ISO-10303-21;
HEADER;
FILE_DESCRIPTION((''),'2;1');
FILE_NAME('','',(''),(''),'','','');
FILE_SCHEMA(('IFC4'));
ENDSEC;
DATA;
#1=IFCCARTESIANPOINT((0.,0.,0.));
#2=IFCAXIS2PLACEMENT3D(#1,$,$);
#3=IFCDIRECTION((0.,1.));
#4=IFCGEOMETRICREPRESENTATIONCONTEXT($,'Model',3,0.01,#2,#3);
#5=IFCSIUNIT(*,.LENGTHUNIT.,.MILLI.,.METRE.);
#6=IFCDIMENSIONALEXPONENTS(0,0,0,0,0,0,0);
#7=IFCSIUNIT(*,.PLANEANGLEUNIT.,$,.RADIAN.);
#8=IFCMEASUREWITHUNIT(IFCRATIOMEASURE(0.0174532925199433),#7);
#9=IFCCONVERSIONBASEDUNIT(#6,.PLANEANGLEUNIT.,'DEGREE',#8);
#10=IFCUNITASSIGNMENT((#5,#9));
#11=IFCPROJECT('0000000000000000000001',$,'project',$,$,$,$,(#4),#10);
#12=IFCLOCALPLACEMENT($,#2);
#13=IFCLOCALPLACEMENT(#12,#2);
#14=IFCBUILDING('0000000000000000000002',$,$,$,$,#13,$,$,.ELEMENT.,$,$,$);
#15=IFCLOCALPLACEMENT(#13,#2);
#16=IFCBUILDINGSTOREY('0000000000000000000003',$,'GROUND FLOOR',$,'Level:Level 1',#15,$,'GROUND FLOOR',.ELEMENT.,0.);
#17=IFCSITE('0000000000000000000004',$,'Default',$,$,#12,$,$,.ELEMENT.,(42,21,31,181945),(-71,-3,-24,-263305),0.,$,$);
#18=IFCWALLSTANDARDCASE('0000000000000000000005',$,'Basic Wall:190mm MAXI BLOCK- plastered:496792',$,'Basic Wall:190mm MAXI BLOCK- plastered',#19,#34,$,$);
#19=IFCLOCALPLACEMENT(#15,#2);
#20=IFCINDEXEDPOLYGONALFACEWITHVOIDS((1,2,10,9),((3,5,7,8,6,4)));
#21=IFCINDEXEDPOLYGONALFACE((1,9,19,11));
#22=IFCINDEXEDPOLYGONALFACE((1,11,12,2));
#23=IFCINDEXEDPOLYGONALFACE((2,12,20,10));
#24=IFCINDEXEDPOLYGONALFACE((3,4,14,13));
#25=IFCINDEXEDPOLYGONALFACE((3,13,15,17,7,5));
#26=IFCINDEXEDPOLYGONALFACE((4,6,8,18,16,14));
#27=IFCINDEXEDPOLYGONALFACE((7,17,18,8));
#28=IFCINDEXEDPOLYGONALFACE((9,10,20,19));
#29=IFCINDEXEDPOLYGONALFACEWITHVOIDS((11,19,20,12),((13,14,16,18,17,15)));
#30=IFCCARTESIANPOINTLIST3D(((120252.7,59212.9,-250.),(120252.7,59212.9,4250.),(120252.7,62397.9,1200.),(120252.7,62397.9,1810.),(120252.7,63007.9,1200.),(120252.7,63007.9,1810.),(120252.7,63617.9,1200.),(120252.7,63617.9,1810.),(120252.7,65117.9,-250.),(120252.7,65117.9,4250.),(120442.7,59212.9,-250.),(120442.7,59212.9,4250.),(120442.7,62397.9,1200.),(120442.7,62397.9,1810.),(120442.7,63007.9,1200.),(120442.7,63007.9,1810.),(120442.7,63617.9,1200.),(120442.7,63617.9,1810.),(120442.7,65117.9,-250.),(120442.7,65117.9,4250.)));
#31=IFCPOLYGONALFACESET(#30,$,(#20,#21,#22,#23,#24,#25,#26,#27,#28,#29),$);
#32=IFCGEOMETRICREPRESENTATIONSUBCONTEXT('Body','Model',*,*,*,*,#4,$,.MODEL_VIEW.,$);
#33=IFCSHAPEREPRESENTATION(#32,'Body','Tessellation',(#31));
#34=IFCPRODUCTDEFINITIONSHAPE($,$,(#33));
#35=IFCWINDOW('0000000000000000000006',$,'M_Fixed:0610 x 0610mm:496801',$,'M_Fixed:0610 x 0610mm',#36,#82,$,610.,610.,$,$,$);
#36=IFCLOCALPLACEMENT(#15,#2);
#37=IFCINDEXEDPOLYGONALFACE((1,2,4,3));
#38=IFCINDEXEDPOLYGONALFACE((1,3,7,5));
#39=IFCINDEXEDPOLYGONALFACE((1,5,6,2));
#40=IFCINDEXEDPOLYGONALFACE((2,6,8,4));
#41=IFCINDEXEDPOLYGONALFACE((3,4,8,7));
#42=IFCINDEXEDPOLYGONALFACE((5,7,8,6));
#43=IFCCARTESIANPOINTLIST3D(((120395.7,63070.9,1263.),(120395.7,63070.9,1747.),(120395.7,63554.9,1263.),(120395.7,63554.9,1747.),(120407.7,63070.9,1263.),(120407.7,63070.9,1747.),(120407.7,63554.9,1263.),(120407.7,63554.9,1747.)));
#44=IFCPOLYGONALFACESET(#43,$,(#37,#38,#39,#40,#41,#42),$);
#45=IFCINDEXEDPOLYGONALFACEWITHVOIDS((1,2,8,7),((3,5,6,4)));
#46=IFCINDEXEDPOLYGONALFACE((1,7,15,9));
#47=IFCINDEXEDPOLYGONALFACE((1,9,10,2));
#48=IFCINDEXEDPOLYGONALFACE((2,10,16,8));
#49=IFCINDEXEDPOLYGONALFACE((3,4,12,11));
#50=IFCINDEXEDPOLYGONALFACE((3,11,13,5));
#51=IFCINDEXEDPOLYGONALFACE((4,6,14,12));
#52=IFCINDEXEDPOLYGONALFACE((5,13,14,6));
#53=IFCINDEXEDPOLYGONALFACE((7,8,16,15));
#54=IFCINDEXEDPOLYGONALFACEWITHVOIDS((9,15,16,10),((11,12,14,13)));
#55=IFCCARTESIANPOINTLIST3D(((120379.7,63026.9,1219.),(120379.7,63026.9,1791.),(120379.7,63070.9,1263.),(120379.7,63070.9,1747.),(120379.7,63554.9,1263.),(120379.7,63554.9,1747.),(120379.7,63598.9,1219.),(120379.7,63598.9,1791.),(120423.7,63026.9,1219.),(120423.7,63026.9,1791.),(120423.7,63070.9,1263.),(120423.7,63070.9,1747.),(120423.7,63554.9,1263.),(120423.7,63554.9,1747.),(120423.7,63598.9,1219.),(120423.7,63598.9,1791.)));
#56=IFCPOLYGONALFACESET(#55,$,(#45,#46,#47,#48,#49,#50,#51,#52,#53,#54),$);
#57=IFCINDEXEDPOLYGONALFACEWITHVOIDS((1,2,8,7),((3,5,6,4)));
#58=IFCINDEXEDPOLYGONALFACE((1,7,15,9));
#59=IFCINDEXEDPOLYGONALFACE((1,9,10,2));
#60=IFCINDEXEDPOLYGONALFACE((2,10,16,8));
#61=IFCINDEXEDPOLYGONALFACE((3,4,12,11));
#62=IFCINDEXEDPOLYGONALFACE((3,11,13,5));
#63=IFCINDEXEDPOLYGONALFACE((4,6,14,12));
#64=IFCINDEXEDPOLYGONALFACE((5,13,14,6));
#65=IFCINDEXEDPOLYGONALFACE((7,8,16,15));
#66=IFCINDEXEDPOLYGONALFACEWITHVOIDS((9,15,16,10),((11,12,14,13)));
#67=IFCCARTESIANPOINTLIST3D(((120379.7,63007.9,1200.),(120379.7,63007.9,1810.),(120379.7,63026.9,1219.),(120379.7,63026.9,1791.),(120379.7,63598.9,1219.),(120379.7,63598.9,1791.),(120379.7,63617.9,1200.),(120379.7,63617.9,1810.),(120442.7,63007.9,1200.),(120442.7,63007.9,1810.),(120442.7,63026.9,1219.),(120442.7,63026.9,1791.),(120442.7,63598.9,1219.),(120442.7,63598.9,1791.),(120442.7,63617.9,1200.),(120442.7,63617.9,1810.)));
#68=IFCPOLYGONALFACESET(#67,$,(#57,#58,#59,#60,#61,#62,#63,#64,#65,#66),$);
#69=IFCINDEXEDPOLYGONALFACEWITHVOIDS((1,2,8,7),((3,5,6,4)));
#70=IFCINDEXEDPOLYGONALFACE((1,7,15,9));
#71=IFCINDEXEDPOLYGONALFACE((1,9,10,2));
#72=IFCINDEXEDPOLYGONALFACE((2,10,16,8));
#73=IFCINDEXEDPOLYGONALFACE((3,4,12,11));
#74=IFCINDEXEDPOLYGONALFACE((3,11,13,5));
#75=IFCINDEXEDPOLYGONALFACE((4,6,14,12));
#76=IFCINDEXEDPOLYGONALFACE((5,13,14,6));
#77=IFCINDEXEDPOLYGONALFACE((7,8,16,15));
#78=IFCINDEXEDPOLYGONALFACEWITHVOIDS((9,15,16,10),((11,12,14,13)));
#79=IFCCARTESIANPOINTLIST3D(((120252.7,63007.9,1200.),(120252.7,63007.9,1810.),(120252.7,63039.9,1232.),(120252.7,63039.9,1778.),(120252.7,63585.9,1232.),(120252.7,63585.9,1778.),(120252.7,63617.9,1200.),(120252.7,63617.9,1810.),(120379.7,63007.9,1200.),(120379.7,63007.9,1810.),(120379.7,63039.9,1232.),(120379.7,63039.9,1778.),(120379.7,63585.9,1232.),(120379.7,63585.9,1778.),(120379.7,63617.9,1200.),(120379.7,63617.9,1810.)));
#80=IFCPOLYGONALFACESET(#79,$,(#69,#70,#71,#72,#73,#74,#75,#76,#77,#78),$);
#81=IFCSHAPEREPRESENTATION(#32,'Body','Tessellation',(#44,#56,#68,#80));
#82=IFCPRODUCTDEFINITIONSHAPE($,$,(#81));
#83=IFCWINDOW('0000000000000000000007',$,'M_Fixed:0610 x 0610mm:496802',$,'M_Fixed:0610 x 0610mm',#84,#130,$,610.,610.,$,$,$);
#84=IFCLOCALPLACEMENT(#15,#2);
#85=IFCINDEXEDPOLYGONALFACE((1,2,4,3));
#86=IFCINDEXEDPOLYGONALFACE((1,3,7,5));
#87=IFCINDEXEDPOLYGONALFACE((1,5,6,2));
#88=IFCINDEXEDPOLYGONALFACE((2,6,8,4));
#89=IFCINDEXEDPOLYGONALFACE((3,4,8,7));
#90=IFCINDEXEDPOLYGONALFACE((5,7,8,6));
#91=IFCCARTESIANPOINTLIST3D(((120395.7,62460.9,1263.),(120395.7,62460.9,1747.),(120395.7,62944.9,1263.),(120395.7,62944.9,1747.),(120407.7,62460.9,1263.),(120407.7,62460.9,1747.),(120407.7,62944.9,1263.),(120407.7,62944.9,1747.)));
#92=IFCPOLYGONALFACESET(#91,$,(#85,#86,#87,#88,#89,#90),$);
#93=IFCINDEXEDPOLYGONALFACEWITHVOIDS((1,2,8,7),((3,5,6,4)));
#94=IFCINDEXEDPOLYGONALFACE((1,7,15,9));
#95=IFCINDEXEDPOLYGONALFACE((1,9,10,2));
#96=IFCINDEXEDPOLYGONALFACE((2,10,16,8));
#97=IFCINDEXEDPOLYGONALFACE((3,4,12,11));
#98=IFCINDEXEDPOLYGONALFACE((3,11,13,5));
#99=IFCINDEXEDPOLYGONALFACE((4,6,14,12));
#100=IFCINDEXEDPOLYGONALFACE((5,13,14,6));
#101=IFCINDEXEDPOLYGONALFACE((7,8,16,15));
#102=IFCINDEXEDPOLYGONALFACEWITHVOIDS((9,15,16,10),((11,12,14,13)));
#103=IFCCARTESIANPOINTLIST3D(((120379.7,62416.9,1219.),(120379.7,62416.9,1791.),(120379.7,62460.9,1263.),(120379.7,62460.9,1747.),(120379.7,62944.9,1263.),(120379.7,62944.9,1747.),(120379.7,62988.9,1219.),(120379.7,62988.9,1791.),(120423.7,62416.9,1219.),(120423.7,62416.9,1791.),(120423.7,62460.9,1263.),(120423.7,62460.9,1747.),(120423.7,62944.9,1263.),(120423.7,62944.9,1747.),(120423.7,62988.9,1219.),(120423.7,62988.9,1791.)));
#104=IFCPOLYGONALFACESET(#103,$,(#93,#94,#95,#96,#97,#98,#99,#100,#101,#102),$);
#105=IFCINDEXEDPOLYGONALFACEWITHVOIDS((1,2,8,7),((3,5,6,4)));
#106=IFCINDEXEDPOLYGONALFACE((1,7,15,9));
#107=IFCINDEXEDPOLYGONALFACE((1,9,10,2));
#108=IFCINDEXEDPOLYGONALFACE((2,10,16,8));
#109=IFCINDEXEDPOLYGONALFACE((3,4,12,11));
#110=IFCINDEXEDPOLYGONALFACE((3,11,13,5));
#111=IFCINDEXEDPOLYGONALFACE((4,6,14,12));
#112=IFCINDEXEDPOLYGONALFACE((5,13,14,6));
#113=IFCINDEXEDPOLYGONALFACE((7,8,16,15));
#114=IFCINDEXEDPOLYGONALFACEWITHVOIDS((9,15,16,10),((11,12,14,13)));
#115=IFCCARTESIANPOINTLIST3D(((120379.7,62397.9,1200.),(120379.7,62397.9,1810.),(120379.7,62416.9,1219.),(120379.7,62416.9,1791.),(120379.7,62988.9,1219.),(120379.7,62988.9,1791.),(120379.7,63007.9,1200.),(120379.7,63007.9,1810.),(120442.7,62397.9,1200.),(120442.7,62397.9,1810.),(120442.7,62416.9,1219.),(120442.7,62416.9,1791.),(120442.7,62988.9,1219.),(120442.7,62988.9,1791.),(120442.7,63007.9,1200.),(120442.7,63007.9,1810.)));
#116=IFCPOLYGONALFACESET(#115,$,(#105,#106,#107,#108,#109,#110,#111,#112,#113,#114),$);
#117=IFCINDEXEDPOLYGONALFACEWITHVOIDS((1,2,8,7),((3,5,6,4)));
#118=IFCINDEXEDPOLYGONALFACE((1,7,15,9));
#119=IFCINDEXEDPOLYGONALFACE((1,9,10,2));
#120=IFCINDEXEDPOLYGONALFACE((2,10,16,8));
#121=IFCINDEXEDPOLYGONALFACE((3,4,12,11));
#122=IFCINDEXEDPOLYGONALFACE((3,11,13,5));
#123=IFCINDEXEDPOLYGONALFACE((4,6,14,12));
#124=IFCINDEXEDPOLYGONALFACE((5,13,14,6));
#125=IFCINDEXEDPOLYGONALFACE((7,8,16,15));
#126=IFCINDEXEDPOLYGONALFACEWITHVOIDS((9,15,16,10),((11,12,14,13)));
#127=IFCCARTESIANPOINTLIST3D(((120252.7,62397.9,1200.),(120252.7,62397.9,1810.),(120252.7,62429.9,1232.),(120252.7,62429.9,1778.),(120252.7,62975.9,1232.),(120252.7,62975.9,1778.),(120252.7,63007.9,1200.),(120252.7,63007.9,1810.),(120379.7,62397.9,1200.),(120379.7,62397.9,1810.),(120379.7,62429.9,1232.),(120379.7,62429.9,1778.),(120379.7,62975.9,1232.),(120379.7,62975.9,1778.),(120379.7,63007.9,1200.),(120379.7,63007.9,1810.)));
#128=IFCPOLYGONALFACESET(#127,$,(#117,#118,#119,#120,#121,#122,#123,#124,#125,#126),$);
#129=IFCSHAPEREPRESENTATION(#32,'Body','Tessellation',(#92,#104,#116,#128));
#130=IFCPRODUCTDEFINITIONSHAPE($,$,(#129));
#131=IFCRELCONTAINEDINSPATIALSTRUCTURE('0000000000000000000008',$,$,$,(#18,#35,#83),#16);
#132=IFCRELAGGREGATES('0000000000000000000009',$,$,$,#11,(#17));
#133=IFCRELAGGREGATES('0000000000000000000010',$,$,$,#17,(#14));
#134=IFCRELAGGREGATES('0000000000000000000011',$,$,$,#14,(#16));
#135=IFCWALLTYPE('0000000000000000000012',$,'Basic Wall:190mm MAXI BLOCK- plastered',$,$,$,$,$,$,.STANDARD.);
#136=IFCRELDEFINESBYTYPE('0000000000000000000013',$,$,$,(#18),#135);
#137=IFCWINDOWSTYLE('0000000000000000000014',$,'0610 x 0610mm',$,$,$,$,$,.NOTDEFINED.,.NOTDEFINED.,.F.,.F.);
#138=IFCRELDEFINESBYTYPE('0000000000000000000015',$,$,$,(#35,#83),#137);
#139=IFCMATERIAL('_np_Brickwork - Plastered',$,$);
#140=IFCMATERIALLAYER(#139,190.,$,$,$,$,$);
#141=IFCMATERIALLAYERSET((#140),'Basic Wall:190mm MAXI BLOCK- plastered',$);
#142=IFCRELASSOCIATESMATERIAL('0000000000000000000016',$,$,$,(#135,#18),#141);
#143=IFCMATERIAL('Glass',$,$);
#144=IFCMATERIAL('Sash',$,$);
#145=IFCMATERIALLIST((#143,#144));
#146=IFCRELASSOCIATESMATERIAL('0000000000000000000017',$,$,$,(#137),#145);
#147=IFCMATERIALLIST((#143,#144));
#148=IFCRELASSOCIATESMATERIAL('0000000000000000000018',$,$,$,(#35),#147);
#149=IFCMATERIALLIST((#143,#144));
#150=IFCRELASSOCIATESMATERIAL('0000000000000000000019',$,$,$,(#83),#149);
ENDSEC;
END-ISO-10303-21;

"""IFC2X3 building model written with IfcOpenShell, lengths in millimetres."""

from ifc_helpers import new_model, entity, si_unit, converted_unit, direction, frame, frame_2d, origin, place, context, subcontext, project, spatial, polyline, rectangle, outline, extrude, source, transform, mapped, material, material_list, layer, layer_set, layer_usage, type_object, type_shapes, element, fill, save


model = new_model("IFC2X3")

# Units and contexts
model_context = context("Model", 3, precision=0.01, world=origin(), true_north=direction((0.0, 1.0)))
body_context = subcontext(model_context, "Body", "Model", "MODEL_VIEW")
ifc_project = project(units=[si_unit("LENGTHUNIT", "METRE", prefix="MILLI"), converted_unit("PLANEANGLEUNIT", "DEGREE", entity("IfcRatioMeasure", 0.0174532925199433), si_unit("PLANEANGLEUNIT", "RADIAN"), dimensions=[0, 0, 0, 0, 0, 0, 0])], contexts=[model_context])

# Site, building, storey
site_placement = place(None, origin())
site = spatial("IfcSite", under=ifc_project, at=site_placement, Name="Default", CompositionType="ELEMENT", RefLatitude=(42, 21, 31, 181945), RefLongitude=(-71, -3, -24, -263305), RefElevation=0.0)
building_placement = place(site_placement, origin())
building = spatial("IfcBuilding", under=site, at=building_placement, CompositionType="ELEMENT")
storey_placement = place(building_placement, origin())
storey = spatial("IfcBuildingStorey", under=building, at=storey_placement, Name="GROUND FLOOR", ObjectType="Level:Level 1", LongName="GROUND FLOOR", CompositionType="ELEMENT", Elevation=0.0)

# Wall, openings, windows
ifc_material_1 = material(Name="_np_Brickwork - Plastered")
ifc_layer = layer(ifc_material_1, 190.0)
ifc_layer_set = layer_set([ifc_layer], Name="Basic Wall:190mm MAXI BLOCK- plastered")
wall_type = type_object("IfcWallType", Name="Basic Wall:190mm MAXI BLOCK- plastered", PredefinedType="STANDARD", material=ifc_layer_set)
ifc_material_2 = material(Name="Glass")
ifc_material_3 = material(Name="Sash")
ifc_material_list_1 = material_list([ifc_material_2, ifc_material_3])
window_style = type_object("IfcWindowStyle", Name="0610 x 0610mm", ConstructionType="NOTDEFINED", OperationType="NOTDEFINED", ParameterTakesPrecedence=False, Sizeable=False, material=ifc_material_list_1)
shared_shape = source(origin(), body_context, "Body", "SweptSolid", [
    extrude(rectangle(XDim=12.0, YDim=484.0, at=frame_2d((0.0, 0.0), x_axis=(1.0, 0.0))), frame((305.0, 149.0, 63.0), z_axis=(0.0, 0.0, 1.0), x_axis=(0.0, -1.0, 0.0)), (0.0, 0.0, 1.0), 484.0),
    extrude(outline(polyline([(-286.0, -286.0), (286.0, -286.0), (286.0, 286.0), (-286.0, 286.0), (-286.0, -286.0)]), holes=[polyline([(-242.0, -242.0), (-242.0, 242.0), (242.0, 242.0), (242.0, -242.0), (-242.0, -242.0)])]), frame((305.0, 127.0, 305.0), z_axis=(0.0, 1.0, 0.0), x_axis=(1.0, 0.0, 0.0)), (0.0, 0.0, 1.0), 44.0),
    extrude(outline(polyline([(-305.0, -305.0), (305.0, -305.0), (305.0, 305.0), (-305.0, 305.0), (-305.0, -305.0)]), holes=[polyline([(-286.0, -286.0), (-286.0, 286.0), (286.0, 286.0), (286.0, -286.0), (-286.0, -286.0)])]), frame((305.0, 127.0, 305.0), z_axis=(0.0, 1.0, 0.0), x_axis=(1.0, 0.0, 0.0)), (0.0, 0.0, 1.0), 63.0),
    extrude(outline(polyline([(-305.0, -305.0), (305.0, -305.0), (305.0, 305.0), (-305.0, 305.0), (-305.0, -305.0)]), holes=[polyline([(-273.0, -273.0), (-273.0, 273.0), (273.0, 273.0), (273.0, -273.0), (-273.0, -273.0)])]), frame((305.0, 0.0, 305.0), z_axis=(0.0, 1.0, 0.0), x_axis=(1.0, 0.0, 0.0)), (0.0, 0.0, 1.0), 127.0),
])
type_shapes(window_style, [shared_shape])
ifc_layer_usage_1 = layer_usage(ifc_layer_set, "AXIS2", "NEGATIVE", 95.0)
wall_1_placement = place(storey_placement, frame((120347.7, 59212.9, -250.0), z_axis=(0.0, 0.0, 1.0), x_axis=(0.0, 1.0, 0.0)))
wall_1 = element("IfcWallStandardCase", 1, at=wall_1_placement, inside=storey, type_object=wall_type, material=ifc_layer_usage_1, Name="Basic Wall:190mm MAXI BLOCK- plastered:496792", ObjectType="Basic Wall:190mm MAXI BLOCK- plastered", context=body_context, shape_type="SweptSolid", body=[
    extrude(rectangle(XDim=5905.0, YDim=190.0, at=frame_2d((2952.5, 0.0), x_axis=(-1.0, 0.0))), origin(), (0.0, 0.0, 1.0), 4500.0),
])
opening_1_placement = place(wall_1_placement, frame((4405.0, 95.0, 1450.0)))
opening_1 = element("IfcOpeningElement", 2, at=opening_1_placement, cuts=wall_1, ObjectType="Opening", context=body_context, shape_type="SweptSolid", body=[
    extrude(rectangle(XDim=610.0, YDim=610.0, at=frame_2d((305.0, 305.0), x_axis=(1.0, 0.0))), frame((0.0, 0.0, 0.0), z_axis=(0.0, -1.0, 0.0), x_axis=(0.0, 0.0, 1.0)), (0.0, 0.0, 1.0), 190.0),
])
opening_2_placement = place(wall_1_placement, frame((3795.0, 95.0, 1450.0)))
opening_2 = element("IfcOpeningElement", 3, at=opening_2_placement, cuts=wall_1, ObjectType="Opening", context=body_context, shape_type="SweptSolid", body=[
    extrude(rectangle(XDim=610.0, YDim=610.0, at=frame_2d((305.0, 305.0), x_axis=(1.0, 0.0))), frame((0.0, 0.0, 0.0), z_axis=(0.0, -1.0, 0.0), x_axis=(0.0, 0.0, 1.0)), (0.0, 0.0, 1.0), 190.0),
])
ifc_material_list_2 = material_list([ifc_material_2, ifc_material_3])
window_1_placement = place(opening_1_placement, frame((0.0, 0.0, 0.0), z_axis=(0.0, 0.0, 1.0), x_axis=(-1.0, 0.0, 0.0)))
window_1 = element("IfcWindow", 4, at=window_1_placement, inside=storey, type_object=window_style, material=ifc_material_list_2, Name="M_Fixed:0610 x 0610mm:496801", ObjectType="M_Fixed:0610 x 0610mm", OverallHeight=610.0, OverallWidth=610.0, context=body_context, shape_type="MappedRepresentation", body=[
    mapped(shared_shape, transform((0.0, 0.0, 0.0), scale=1.0)),
])
fill(opening_1, window_1)
ifc_material_list_3 = material_list([ifc_material_2, ifc_material_3])
window_2_placement = place(opening_2_placement, frame((0.0, 0.0, 0.0), z_axis=(0.0, 0.0, 1.0), x_axis=(-1.0, 0.0, 0.0)))
window_2 = element("IfcWindow", 5, at=window_2_placement, inside=storey, type_object=window_style, material=ifc_material_list_3, Name="M_Fixed:0610 x 0610mm:496802", ObjectType="M_Fixed:0610 x 0610mm", OverallHeight=610.0, OverallWidth=610.0, context=body_context, shape_type="MappedRepresentation", body=[
    mapped(shared_shape, transform((0.0, 0.0, 0.0), scale=1.0)),
])
fill(opening_2, window_2)

save(model, "model.ifc")
